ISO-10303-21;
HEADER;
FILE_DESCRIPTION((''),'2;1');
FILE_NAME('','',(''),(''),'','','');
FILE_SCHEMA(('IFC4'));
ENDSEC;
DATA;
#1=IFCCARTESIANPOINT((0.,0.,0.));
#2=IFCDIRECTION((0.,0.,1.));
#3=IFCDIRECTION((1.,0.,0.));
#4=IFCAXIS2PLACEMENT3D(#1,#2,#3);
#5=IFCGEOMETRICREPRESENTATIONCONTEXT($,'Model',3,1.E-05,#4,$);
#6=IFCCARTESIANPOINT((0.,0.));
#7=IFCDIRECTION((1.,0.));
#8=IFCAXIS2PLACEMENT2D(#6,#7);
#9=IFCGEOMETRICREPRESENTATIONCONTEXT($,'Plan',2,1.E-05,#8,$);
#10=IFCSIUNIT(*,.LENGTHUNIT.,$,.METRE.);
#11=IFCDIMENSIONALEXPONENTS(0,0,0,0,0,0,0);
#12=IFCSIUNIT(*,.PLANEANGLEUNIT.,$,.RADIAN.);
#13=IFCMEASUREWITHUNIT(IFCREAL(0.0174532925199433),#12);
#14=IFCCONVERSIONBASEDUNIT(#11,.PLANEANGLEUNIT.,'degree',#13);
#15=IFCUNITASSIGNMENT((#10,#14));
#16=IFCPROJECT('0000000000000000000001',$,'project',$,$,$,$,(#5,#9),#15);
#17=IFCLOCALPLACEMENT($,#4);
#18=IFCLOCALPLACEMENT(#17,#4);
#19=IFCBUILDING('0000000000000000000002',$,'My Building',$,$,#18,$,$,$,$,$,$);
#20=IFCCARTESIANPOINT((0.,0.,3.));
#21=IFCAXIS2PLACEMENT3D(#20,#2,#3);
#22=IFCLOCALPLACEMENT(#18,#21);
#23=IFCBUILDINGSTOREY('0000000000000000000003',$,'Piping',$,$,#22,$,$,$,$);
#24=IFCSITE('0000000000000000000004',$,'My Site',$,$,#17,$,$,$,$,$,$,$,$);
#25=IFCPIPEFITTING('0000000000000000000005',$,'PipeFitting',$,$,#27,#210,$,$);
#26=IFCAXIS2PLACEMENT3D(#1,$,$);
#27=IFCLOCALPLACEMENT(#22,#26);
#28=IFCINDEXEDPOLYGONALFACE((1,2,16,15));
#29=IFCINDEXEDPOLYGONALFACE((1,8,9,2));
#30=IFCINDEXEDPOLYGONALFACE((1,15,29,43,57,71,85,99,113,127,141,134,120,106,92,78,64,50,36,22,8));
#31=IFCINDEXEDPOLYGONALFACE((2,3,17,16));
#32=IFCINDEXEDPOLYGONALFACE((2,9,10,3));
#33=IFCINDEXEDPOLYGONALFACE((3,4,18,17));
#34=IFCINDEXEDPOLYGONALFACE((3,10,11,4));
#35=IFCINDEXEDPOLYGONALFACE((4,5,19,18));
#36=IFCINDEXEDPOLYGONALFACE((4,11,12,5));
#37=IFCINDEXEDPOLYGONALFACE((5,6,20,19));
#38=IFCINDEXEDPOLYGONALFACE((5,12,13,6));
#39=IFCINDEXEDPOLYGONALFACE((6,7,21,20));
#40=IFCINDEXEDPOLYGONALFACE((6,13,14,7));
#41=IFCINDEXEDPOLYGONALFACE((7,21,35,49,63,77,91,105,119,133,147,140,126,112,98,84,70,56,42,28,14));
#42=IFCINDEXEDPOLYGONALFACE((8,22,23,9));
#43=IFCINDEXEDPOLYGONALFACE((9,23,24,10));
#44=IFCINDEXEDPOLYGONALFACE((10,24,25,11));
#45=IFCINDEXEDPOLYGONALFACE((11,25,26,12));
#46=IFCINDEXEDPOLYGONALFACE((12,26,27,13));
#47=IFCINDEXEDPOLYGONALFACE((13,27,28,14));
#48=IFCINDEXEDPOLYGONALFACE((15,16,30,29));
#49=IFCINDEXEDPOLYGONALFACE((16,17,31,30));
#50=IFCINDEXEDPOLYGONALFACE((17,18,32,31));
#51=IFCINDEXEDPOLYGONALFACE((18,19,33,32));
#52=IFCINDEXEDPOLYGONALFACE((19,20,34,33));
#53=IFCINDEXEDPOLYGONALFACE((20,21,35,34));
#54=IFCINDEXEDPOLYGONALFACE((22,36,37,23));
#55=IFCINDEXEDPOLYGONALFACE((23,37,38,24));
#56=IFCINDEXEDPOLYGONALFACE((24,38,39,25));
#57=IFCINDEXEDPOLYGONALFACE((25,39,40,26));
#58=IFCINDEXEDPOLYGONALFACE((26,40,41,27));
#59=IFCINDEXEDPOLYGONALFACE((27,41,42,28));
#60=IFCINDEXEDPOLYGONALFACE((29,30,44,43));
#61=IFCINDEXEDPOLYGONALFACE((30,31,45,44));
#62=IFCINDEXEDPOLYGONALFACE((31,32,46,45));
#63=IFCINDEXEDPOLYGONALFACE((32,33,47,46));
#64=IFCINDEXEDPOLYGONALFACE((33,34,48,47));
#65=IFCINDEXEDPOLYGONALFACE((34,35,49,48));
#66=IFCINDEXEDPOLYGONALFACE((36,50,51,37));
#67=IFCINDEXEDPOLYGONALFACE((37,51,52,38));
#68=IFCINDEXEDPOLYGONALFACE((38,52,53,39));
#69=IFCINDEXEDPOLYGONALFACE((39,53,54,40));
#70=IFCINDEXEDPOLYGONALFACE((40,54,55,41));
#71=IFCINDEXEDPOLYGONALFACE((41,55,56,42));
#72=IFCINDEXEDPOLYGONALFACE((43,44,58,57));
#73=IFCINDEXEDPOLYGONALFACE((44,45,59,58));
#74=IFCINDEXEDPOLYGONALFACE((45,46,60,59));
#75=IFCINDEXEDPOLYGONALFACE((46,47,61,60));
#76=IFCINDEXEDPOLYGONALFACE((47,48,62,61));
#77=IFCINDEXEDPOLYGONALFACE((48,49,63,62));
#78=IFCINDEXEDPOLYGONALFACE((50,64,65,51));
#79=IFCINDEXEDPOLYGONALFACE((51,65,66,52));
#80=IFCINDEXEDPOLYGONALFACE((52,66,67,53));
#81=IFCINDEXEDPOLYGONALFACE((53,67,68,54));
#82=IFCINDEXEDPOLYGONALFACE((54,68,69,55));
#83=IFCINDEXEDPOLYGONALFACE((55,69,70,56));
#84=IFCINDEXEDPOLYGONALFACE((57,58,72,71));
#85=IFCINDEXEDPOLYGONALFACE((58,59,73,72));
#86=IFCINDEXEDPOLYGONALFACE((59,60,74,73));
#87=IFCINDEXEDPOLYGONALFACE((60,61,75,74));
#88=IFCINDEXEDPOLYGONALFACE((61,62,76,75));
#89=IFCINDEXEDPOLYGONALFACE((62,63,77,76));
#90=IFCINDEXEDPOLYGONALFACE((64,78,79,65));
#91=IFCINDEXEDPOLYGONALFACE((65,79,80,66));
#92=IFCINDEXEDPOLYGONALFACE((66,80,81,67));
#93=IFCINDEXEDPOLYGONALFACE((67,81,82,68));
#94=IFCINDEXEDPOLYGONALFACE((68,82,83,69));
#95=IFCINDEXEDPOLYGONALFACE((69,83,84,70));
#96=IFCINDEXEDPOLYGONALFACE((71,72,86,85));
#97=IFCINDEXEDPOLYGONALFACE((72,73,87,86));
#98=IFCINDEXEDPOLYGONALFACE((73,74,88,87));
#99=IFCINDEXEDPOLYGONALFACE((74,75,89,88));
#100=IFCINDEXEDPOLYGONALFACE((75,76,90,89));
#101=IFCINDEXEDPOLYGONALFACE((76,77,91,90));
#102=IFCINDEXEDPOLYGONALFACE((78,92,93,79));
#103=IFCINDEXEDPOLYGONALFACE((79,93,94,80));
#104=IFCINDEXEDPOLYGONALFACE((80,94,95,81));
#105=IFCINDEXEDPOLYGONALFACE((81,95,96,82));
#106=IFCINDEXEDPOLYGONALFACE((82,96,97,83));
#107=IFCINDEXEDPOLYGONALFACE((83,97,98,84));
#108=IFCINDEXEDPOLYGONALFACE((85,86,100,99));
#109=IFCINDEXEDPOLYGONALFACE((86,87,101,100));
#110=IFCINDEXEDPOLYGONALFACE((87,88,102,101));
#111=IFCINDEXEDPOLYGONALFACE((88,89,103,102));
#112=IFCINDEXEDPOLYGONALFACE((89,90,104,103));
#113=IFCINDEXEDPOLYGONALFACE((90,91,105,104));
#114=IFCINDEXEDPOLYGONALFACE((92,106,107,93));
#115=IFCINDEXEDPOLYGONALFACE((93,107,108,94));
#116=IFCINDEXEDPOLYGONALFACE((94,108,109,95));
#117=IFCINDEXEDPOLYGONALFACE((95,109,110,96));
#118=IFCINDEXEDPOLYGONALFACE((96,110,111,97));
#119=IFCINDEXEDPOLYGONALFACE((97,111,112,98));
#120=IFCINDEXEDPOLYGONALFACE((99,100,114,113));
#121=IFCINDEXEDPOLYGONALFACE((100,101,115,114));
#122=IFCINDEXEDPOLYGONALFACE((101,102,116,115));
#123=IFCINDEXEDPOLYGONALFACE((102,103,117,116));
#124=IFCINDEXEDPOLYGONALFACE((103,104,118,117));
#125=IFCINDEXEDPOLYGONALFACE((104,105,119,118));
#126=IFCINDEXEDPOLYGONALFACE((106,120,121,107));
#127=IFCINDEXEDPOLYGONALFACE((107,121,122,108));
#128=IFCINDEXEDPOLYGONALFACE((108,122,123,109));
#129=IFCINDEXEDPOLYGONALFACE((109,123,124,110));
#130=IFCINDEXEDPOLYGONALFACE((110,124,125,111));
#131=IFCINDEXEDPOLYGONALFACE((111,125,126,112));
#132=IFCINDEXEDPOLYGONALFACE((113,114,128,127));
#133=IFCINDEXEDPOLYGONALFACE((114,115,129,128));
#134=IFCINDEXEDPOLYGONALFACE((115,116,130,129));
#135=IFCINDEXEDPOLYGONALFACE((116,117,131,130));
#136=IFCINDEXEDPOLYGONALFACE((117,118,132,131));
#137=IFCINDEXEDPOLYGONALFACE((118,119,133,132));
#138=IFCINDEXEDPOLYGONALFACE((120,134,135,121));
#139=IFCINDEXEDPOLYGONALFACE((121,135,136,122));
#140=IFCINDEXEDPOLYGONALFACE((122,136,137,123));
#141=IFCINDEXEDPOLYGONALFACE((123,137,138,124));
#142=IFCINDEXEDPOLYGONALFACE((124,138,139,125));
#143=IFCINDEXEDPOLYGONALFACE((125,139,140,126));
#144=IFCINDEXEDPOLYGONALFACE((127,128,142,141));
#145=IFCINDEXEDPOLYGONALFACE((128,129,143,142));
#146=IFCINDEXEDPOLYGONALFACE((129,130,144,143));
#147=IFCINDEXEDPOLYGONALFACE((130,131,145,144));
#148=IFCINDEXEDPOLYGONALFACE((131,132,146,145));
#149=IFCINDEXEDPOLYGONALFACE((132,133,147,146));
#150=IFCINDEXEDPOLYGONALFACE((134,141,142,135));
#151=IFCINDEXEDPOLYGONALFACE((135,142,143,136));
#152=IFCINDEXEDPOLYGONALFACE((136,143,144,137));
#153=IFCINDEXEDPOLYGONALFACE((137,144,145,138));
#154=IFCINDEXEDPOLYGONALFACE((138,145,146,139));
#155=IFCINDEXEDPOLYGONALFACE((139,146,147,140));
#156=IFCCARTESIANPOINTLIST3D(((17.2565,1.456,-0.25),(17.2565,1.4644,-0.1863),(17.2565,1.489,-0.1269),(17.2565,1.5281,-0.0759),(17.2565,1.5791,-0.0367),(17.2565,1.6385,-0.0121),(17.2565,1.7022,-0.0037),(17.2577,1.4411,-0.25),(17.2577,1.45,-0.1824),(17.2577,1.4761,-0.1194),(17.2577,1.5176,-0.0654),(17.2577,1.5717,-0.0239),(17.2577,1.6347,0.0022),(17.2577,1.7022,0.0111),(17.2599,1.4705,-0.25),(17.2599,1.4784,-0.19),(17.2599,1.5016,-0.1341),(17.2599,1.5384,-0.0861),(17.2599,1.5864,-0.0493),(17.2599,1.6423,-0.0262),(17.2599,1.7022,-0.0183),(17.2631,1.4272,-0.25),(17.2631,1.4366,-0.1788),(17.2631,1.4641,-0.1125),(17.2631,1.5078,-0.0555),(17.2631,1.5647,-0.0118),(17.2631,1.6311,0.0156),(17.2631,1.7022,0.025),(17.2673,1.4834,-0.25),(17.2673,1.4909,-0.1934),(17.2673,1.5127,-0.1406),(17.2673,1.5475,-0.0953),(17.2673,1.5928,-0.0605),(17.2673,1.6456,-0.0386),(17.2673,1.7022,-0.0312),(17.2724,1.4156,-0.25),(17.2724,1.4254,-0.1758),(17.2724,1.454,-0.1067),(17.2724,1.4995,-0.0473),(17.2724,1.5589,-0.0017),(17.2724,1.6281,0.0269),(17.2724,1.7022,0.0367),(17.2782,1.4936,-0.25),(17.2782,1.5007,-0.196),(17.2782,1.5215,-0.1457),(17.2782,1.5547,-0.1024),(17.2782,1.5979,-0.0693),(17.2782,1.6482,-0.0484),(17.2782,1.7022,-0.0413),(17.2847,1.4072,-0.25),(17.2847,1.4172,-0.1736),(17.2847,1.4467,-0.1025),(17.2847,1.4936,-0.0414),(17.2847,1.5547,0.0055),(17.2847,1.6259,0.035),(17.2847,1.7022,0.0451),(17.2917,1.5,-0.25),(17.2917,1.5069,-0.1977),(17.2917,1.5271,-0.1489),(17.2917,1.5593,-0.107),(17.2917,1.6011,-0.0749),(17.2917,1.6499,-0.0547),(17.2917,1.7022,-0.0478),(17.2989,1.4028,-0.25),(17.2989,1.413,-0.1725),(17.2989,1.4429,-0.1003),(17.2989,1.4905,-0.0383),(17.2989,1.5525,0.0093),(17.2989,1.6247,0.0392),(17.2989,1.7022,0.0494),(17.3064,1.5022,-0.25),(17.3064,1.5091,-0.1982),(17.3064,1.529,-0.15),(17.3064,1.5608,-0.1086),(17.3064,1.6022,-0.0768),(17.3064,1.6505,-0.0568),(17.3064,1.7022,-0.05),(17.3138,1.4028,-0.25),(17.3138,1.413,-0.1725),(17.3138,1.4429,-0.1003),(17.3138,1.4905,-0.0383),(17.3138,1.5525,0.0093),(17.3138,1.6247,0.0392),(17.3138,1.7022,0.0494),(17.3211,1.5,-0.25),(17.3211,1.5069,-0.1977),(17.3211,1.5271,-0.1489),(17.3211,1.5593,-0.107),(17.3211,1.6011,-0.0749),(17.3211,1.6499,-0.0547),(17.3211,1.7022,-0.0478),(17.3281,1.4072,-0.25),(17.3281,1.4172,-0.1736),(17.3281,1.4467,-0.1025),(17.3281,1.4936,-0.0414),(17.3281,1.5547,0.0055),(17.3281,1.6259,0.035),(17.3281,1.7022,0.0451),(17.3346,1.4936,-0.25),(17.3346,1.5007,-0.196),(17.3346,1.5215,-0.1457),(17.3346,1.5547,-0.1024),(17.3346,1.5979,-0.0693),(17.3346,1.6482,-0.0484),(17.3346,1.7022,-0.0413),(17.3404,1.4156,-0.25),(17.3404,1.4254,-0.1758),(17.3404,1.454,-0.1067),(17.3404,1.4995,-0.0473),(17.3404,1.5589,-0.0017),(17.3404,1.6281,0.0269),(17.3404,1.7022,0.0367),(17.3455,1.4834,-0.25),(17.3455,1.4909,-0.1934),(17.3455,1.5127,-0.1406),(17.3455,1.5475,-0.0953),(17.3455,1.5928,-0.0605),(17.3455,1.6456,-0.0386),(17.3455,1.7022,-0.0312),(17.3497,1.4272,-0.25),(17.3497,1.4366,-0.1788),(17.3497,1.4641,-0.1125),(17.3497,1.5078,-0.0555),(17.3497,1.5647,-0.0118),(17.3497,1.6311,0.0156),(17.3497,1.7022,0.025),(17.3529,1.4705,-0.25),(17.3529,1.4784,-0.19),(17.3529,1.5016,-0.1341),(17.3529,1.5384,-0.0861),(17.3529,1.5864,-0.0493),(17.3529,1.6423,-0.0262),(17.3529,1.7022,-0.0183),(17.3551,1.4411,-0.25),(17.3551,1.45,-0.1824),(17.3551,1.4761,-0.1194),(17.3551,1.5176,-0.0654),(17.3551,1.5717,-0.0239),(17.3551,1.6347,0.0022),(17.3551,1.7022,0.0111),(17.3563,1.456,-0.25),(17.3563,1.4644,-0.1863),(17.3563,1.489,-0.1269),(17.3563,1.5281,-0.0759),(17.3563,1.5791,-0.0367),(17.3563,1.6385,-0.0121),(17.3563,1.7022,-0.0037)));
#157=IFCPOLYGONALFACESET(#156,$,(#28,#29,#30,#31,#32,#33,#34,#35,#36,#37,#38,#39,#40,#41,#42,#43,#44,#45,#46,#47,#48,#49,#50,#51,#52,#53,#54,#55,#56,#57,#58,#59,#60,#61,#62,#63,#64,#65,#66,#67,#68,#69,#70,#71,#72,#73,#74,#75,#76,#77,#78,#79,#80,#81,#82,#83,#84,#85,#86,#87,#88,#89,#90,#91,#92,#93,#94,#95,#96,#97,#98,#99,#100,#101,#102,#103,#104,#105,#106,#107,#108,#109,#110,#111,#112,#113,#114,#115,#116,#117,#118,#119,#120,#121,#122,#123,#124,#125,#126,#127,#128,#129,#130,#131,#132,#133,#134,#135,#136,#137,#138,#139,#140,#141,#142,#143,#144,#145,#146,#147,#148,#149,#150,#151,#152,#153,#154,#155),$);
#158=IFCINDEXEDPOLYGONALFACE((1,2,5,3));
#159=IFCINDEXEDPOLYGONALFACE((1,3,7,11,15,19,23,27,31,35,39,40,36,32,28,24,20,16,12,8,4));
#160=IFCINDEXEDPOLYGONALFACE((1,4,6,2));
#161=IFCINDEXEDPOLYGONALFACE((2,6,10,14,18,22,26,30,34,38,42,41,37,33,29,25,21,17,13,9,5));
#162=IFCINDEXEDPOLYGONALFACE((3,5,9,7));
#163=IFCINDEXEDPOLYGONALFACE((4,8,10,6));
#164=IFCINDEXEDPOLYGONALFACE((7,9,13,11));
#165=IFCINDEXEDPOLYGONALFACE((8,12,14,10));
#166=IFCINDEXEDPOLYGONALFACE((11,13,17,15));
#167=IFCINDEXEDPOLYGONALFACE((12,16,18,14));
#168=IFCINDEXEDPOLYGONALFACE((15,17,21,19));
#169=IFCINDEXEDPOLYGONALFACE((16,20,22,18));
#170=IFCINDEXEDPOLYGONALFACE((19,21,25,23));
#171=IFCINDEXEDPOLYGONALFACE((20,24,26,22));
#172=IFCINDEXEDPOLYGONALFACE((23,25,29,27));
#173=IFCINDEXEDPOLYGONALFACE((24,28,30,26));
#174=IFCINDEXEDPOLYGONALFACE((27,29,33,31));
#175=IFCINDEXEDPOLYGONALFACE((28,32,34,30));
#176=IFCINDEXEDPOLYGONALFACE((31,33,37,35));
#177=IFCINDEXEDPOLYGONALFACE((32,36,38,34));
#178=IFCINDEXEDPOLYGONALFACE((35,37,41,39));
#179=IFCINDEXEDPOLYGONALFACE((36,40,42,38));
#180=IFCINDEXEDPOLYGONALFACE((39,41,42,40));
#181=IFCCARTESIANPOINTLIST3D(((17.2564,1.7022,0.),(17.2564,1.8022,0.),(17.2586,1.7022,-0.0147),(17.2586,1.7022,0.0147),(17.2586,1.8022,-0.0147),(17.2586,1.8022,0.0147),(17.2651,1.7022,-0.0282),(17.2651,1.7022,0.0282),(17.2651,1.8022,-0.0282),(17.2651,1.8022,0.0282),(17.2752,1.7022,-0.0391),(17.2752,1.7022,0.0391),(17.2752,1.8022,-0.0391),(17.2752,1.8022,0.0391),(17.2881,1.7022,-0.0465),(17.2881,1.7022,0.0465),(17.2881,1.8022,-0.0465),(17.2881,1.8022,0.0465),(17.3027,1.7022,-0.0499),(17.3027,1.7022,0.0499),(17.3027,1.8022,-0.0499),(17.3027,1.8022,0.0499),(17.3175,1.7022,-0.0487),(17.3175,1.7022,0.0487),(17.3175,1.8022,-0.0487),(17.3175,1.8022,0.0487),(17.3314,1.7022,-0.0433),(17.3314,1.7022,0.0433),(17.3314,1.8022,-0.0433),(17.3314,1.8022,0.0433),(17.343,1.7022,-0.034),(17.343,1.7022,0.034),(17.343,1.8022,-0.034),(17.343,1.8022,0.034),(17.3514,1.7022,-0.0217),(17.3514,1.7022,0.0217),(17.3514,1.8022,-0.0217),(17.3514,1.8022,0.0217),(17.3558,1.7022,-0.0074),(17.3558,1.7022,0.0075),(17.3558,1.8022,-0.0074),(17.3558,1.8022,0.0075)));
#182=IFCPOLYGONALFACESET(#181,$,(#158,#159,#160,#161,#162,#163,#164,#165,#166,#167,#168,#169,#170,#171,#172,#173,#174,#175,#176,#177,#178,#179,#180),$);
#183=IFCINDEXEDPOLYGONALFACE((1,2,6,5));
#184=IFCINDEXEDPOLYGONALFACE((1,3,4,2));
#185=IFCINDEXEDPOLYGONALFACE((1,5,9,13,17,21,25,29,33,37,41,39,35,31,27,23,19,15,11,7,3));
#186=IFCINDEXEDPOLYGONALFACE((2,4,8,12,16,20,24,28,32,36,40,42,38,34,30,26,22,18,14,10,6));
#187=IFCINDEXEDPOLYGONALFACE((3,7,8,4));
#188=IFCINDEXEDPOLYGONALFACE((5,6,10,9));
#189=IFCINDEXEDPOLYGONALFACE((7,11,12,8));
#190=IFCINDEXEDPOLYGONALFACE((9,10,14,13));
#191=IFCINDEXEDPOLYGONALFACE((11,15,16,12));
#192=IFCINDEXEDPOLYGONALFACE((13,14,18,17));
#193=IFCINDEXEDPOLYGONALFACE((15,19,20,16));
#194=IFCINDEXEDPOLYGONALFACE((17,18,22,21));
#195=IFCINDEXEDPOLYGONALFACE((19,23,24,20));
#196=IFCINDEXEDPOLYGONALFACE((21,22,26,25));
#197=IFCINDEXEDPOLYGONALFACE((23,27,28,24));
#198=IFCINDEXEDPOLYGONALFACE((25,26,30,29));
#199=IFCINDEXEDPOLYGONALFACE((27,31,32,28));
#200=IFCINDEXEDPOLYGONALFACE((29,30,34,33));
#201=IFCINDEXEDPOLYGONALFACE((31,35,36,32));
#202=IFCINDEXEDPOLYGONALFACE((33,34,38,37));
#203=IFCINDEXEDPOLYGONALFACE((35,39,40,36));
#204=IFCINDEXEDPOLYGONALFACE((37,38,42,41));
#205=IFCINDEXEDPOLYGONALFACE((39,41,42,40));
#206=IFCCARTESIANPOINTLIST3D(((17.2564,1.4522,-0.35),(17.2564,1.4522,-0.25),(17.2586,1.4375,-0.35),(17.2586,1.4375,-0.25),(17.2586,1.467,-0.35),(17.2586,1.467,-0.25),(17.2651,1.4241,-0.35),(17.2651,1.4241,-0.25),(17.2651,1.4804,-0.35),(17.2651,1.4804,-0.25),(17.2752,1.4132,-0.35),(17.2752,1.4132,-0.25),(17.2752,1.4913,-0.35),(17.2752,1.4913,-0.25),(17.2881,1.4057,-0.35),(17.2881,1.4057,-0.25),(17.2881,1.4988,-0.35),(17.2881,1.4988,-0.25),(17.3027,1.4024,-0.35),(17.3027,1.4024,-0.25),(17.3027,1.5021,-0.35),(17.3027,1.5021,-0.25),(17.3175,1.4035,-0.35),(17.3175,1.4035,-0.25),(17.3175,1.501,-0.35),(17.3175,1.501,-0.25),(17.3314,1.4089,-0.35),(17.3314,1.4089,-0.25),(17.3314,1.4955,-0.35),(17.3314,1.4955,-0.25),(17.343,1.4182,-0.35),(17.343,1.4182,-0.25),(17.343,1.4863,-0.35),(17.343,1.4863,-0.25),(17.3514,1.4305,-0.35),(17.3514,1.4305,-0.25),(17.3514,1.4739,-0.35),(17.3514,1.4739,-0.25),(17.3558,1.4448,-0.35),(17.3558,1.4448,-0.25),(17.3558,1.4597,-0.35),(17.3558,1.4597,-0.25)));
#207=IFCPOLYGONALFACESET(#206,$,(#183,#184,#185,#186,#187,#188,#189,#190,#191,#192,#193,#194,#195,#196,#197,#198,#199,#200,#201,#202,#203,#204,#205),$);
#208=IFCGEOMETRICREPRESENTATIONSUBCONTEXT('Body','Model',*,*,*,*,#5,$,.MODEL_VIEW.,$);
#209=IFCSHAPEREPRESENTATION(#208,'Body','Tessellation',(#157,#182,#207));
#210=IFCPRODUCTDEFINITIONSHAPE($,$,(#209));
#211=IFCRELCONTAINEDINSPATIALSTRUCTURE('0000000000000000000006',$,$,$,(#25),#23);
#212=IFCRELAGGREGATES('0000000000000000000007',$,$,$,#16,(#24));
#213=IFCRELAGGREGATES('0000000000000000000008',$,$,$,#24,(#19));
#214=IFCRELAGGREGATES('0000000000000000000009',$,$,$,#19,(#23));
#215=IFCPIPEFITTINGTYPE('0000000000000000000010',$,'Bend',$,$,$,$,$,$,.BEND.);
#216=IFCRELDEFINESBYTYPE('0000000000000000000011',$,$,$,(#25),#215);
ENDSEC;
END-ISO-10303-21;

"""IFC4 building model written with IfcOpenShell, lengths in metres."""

from ifc_helpers import new_model, entity, si_unit, converted_unit, frame, origin_with_axes, origin_2d_with_axis, place, context, subcontext, project, spatial, circle, extrude, source, transform, mapped, type_object, type_shapes, element, save


model = new_model("IFC4")

# Units and contexts
model_context = context("Model", 3, precision=1e-05, world=origin_with_axes())
plan_context = context("Plan", 2, precision=1e-05, world=origin_2d_with_axis())
body_context = subcontext(model_context, "Body", "Model", "MODEL_VIEW")
ifc_project = project(units=[si_unit("LENGTHUNIT", "METRE"), converted_unit("PLANEANGLEUNIT", "degree", entity("IfcReal", 0.0174532925199433), si_unit("PLANEANGLEUNIT", "RADIAN"), dimensions=[0, 0, 0, 0, 0, 0, 0])], contexts=[model_context, plan_context])

# Site, building, storey
site_placement = place(None, origin_with_axes())
site = spatial("IfcSite", under=ifc_project, at=site_placement, Name="My Site")
building_placement = place(site_placement, origin_with_axes())
building = spatial("IfcBuilding", under=site, at=building_placement, Name="My Building")
storey_placement = place(building_placement, frame((0.0, 0.0, 3.0), z_axis=(0.0, 0.0, 1.0), x_axis=(1.0, 0.0, 0.0)))
storey = spatial("IfcBuildingStorey", under=building, at=storey_placement, Name="Piping")

# Pipe fitting
pipe_fitting_type = type_object("IfcPipeFittingType", Name="Bend", PredefinedType="BEND")
shared_shape = source(origin_with_axes(), body_context, "Body", "SolidModel", [
    entity("IfcSweptDiskSolid", entity("IfcIndexedPolyCurve", entity("IfcCartesianPointList3D", [[0.0, 0.0, -0.1], [0.0, -0.0732, -0.2768], [0.0, -0.25, -0.35]]), [entity("IfcArcIndex", [1, 2, 3])]), 0.05),
    extrude(circle(Radius=0.05), origin_with_axes(), (0.0, 0.0, -1.0), 0.1),
    extrude(circle(Radius=0.05), frame((0.0, -0.25, -0.35), z_axis=(0.0, -1.0, 0.0), x_axis=(1.0, 0.0, 0.0)), (0.0, 0.0, 1.0), 0.1),
])
type_shapes(pipe_fitting_type, [shared_shape])
for number, where, z_axis, x_axis, name in (
    (1, (17.3064, 1.8022, 0.0), (0.0, 1.0, 0.0), (-1.0, 0.0, 0.0), "PipeFitting"),
):
    element("IfcPipeFitting", number, at=place(storey_placement, frame(where, z_axis=z_axis, x_axis=x_axis)), inside=storey, type_object=pipe_fitting_type, Name=name, context=body_context, shape_type="MappedRepresentation", body=[
        mapped(shared_shape, transform((0.0, 0.0, 0.0), x_axis=(1.0, 0.0, 0.0), y_axis=(0.0, 1.0, 0.0), z_axis=(0.0, 0.0, 1.0), scale=1.0)),
    ])

save(model, "model.ifc")
